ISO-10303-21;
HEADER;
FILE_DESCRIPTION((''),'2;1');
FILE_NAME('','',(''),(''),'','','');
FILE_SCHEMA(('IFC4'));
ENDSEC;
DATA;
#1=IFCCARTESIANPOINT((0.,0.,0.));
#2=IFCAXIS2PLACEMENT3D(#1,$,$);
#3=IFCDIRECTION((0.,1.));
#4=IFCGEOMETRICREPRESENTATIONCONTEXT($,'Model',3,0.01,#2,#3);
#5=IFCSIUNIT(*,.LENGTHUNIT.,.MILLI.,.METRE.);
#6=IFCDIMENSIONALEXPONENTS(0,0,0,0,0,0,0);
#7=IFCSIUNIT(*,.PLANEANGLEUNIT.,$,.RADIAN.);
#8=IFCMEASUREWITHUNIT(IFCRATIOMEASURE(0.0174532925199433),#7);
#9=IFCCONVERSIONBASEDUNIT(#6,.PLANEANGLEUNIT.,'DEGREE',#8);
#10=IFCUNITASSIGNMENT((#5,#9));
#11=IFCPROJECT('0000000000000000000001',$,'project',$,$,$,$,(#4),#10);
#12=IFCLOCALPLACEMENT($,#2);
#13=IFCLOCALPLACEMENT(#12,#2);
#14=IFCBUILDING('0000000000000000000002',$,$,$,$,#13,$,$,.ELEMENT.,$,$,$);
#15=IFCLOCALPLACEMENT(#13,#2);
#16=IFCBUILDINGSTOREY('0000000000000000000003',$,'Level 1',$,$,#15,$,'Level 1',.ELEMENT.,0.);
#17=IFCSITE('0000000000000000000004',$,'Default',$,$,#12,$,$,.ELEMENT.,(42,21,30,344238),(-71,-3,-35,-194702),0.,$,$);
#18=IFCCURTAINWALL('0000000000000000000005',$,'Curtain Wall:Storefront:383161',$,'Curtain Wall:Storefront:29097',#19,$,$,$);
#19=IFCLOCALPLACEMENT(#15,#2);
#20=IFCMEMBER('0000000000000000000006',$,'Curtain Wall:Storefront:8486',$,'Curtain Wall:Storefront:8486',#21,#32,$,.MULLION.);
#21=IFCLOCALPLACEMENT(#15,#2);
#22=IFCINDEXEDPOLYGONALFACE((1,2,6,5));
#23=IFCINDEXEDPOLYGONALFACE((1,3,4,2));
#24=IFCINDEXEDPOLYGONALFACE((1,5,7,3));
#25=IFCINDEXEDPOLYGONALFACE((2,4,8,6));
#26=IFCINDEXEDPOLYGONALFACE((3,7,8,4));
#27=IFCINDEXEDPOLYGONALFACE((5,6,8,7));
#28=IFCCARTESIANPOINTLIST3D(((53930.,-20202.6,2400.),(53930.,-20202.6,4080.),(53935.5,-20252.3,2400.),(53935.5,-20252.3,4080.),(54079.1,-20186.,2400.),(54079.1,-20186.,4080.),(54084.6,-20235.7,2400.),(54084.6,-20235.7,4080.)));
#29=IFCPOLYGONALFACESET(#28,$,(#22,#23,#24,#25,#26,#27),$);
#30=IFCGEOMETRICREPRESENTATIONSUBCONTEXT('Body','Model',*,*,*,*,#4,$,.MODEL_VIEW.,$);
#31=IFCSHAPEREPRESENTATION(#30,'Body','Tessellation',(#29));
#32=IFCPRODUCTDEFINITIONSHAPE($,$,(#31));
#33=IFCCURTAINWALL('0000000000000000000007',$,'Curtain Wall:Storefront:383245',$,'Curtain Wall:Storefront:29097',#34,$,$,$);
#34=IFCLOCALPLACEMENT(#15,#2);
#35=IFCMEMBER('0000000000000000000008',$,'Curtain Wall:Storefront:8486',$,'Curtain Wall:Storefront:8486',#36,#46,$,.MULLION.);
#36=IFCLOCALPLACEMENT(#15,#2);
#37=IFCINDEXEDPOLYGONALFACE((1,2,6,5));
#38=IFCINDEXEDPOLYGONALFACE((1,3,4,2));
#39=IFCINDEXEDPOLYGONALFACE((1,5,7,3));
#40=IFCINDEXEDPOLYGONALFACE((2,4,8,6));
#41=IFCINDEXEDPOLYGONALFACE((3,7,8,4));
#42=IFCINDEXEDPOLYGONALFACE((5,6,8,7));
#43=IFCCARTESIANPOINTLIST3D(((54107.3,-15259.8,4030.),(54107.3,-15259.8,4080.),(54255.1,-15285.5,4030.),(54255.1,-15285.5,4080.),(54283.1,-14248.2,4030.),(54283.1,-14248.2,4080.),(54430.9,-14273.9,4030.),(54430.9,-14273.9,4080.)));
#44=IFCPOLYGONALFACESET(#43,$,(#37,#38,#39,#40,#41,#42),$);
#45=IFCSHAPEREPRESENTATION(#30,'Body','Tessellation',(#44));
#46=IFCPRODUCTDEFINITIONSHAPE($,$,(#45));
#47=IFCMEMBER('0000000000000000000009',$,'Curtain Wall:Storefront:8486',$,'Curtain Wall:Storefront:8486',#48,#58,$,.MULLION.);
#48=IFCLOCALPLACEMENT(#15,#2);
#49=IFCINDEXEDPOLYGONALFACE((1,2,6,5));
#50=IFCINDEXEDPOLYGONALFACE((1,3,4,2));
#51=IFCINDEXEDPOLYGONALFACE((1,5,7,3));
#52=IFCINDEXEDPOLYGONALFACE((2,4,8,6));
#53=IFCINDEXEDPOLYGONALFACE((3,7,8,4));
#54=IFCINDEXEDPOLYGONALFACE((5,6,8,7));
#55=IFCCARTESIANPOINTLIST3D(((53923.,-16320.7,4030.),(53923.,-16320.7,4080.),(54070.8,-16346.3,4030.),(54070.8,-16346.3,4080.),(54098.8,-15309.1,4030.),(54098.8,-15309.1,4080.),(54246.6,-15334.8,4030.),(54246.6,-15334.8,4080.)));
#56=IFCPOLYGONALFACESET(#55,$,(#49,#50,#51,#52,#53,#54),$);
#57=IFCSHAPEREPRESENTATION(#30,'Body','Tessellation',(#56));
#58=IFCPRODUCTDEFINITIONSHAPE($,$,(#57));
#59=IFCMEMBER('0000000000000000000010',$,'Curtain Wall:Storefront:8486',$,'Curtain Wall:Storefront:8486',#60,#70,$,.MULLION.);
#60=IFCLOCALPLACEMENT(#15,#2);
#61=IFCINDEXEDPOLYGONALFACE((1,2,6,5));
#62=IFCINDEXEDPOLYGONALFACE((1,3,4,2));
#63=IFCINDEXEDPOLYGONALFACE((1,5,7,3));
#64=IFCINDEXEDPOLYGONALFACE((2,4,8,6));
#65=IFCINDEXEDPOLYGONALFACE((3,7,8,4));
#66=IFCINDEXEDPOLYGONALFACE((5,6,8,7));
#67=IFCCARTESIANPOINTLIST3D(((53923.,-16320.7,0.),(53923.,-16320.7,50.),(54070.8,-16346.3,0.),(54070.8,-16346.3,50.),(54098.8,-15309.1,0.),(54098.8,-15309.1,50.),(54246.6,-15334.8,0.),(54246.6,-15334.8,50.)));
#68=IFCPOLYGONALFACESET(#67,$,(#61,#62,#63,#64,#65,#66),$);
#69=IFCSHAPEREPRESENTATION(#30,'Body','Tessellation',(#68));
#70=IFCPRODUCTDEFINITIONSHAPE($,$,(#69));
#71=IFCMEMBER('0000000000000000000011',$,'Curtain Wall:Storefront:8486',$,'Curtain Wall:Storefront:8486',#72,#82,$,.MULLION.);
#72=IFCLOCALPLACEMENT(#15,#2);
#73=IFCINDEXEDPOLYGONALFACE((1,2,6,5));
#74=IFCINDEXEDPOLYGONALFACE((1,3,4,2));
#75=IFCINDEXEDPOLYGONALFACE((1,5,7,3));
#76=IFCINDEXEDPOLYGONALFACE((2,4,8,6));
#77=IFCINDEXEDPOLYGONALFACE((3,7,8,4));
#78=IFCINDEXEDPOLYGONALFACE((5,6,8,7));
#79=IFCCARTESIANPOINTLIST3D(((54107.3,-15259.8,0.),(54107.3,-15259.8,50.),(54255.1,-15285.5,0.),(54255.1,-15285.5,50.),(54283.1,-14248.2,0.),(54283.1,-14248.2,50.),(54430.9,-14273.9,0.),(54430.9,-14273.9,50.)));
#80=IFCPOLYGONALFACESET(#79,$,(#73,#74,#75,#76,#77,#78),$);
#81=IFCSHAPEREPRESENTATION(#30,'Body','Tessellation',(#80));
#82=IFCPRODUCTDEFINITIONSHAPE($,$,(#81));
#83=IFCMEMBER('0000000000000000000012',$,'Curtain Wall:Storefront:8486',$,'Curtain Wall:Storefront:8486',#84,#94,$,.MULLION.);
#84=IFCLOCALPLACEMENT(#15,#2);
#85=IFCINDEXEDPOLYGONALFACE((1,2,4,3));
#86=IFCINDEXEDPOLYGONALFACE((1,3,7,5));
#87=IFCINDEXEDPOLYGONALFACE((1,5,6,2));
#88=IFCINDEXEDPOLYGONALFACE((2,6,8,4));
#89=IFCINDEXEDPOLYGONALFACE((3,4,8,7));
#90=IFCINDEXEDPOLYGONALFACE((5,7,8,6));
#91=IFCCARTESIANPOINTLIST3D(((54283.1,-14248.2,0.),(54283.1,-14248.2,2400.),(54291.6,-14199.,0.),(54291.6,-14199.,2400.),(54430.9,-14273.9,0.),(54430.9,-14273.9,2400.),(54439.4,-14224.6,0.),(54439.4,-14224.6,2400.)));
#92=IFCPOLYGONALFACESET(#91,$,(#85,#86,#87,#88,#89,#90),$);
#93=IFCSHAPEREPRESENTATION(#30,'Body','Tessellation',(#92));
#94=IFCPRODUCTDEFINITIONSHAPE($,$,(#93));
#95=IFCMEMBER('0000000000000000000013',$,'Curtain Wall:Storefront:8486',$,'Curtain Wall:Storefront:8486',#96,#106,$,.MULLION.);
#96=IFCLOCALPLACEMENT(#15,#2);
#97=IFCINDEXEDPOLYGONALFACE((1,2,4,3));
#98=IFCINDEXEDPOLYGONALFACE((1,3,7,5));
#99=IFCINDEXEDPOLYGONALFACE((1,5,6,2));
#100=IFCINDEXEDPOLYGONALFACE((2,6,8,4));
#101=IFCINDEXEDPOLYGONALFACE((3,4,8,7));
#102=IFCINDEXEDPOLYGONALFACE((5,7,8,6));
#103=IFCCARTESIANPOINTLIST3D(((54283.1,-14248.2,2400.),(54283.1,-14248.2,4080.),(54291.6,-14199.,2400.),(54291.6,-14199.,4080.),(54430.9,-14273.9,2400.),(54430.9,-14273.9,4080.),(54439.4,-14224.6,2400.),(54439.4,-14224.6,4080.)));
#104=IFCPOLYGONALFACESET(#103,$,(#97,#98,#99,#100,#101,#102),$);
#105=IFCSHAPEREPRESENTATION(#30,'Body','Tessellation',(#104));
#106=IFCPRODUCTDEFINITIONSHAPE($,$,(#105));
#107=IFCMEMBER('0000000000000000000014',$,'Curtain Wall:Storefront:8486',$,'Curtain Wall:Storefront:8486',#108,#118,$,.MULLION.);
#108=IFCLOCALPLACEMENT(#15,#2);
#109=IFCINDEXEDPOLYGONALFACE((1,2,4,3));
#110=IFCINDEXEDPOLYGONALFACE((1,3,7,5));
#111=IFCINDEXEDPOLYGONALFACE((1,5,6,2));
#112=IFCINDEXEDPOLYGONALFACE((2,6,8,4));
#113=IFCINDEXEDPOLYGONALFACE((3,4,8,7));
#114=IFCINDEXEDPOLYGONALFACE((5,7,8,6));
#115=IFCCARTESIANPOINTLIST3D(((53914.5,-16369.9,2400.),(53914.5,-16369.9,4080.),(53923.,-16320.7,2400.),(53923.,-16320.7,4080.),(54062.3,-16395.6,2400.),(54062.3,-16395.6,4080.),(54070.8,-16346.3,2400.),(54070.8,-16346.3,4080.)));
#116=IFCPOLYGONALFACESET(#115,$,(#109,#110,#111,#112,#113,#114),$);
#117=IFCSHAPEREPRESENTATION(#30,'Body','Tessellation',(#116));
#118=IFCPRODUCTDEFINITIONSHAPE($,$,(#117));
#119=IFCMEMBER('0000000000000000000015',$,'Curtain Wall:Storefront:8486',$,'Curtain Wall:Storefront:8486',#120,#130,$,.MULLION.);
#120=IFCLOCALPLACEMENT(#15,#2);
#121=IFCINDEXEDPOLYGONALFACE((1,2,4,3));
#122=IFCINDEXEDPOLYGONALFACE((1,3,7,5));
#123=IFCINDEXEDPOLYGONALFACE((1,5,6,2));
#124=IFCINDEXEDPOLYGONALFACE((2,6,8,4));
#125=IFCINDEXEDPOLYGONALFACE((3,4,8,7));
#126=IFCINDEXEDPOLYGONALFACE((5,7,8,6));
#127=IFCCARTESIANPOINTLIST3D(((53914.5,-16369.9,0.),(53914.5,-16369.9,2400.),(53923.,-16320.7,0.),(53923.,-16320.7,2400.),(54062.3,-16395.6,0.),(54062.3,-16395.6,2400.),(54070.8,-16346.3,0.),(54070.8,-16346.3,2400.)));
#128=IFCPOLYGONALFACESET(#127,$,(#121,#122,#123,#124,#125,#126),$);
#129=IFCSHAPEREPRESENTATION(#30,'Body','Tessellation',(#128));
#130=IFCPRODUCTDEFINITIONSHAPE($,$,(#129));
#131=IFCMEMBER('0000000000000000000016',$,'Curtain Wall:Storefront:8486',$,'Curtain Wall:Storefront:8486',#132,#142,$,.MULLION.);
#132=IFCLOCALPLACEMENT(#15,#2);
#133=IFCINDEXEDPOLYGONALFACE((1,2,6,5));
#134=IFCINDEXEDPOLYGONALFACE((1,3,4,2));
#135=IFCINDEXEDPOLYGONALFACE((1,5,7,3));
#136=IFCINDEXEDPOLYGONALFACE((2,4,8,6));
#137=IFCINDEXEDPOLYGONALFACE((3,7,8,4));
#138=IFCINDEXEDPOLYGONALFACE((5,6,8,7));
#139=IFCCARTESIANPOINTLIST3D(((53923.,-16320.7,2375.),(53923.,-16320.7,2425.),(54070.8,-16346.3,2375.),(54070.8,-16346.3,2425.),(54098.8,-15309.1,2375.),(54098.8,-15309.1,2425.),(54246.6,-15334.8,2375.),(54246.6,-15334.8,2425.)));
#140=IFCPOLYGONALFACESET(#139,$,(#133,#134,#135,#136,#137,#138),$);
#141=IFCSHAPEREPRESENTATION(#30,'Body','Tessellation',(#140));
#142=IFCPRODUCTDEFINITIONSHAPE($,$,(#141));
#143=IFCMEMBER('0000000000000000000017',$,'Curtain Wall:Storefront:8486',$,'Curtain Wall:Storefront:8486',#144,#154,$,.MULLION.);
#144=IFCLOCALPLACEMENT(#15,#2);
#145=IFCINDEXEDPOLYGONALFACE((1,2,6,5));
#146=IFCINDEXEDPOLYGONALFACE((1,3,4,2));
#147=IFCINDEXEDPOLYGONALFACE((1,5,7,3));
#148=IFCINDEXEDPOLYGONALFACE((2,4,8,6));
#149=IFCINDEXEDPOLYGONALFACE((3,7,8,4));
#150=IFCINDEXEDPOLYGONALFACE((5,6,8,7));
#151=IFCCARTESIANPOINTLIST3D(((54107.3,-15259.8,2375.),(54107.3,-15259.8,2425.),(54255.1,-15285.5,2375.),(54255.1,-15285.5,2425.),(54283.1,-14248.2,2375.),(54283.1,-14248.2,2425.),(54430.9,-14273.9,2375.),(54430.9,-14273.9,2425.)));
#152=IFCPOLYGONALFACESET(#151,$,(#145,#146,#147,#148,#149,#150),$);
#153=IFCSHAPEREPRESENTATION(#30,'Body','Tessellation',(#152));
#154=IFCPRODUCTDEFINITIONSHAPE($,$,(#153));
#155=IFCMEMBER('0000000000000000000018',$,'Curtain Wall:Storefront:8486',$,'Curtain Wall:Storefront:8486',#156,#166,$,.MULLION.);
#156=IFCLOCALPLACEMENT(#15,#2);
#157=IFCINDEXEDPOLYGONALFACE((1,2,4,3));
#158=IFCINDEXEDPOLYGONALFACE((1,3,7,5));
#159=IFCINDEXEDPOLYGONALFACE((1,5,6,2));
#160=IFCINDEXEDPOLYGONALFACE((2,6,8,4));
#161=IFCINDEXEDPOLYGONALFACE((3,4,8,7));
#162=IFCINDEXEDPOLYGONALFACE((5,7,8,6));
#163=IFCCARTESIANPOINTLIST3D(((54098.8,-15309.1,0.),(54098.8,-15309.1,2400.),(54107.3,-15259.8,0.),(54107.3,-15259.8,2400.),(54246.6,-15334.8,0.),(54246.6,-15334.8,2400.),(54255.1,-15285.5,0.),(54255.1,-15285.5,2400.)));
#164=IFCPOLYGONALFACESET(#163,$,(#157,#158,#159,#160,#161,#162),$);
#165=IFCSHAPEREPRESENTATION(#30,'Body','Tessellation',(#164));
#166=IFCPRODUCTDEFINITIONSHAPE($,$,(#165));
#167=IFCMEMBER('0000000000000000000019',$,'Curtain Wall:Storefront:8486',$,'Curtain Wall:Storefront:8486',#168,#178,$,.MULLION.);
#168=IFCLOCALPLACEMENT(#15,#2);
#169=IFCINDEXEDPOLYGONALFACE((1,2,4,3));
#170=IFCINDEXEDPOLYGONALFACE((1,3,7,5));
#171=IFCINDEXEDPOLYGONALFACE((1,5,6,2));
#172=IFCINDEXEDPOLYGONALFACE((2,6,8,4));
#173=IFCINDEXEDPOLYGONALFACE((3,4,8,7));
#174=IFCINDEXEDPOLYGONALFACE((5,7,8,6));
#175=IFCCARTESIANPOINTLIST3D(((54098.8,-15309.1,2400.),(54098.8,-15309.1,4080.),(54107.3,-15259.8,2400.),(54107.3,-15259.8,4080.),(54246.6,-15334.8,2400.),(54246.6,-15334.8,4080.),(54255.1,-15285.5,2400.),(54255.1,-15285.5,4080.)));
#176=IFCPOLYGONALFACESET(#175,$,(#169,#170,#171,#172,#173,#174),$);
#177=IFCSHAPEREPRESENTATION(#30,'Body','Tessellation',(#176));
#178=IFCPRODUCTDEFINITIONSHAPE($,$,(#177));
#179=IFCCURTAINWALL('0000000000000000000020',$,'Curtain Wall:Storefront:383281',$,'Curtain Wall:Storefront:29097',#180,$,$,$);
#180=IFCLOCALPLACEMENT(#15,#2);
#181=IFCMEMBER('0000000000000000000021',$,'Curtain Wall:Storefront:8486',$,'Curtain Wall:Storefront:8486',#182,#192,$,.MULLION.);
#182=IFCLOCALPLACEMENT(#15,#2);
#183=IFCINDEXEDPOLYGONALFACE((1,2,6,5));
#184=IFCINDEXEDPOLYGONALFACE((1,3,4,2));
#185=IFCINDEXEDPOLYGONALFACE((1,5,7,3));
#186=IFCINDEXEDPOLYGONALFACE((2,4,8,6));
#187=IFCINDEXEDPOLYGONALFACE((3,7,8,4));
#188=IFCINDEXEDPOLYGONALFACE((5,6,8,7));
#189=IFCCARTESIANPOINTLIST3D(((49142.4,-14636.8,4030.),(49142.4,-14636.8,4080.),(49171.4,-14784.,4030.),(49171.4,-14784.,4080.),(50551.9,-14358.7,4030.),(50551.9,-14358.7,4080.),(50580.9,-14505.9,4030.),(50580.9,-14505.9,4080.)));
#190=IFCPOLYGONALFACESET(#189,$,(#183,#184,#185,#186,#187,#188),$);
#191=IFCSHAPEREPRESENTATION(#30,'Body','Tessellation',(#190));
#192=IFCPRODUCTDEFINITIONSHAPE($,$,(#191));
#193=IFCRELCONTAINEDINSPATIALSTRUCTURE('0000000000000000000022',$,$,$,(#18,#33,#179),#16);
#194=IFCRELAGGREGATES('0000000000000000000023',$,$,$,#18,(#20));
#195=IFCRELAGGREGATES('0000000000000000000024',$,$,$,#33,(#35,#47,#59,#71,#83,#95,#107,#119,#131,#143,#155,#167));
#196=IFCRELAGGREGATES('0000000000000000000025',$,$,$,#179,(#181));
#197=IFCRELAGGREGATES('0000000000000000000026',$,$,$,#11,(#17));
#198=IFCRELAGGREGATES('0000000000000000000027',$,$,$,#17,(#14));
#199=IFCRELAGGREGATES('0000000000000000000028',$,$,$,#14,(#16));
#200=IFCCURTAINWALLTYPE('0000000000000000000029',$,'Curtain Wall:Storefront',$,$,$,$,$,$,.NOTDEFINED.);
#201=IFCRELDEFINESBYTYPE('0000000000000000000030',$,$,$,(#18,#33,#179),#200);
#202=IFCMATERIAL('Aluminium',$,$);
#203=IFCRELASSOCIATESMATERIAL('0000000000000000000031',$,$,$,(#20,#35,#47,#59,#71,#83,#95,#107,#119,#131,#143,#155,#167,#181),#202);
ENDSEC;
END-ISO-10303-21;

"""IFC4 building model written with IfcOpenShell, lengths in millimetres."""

from ifc_helpers import new_model, entity, si_unit, converted_unit, direction, frame, frame_2d, origin, origin_2d_with_axis, place, context, subcontext, project, spatial, rectangle, extrude, material, type_object, element, aggregate, save


model = new_model("IFC4")

# Units and contexts
model_context = context("Model", 3, precision=0.01, world=origin(), true_north=direction((0.0, 1.0)))
body_context = subcontext(model_context, "Body", "Model", "MODEL_VIEW")
ifc_project = project(units=[si_unit("LENGTHUNIT", "METRE", prefix="MILLI"), converted_unit("PLANEANGLEUNIT", "DEGREE", entity("IfcRatioMeasure", 0.0174532925199433), si_unit("PLANEANGLEUNIT", "RADIAN"), dimensions=[0, 0, 0, 0, 0, 0, 0])], contexts=[model_context])

# Site, building, storey
site_placement = place(None, origin())
site = spatial("IfcSite", under=ifc_project, at=site_placement, Name="Default", CompositionType="ELEMENT", RefLatitude=(42, 21, 30, 344238), RefLongitude=(-71, -3, -35, -194702), RefElevation=0.0)
building_placement = place(site_placement, origin())
building = spatial("IfcBuilding", under=site, at=building_placement, CompositionType="ELEMENT")
storey_placement = place(building_placement, origin())
storey = spatial("IfcBuildingStorey", under=building, at=storey_placement, Name="Level 1", LongName="Level 1", CompositionType="ELEMENT", Elevation=0.0)

# Curtain walls, members
curtain_wall_type = type_object("IfcCurtainWallType", Name="Curtain Wall:Storefront", PredefinedType="NOTDEFINED")
ifc_material = material(Name="Aluminium")
curtain_wall_1_placement = place(storey_placement, origin())
curtain_wall_1 = element("IfcCurtainWall", 1, at=curtain_wall_1_placement, inside=storey, type_object=curtain_wall_type, Name="Curtain Wall:Storefront:383161", ObjectType="Curtain Wall:Storefront:29097")
member_1_placement = place(curtain_wall_1_placement, origin())
member_1 = element("IfcMember", 2, at=member_1_placement, material=ifc_material, Name="Curtain Wall:Storefront:8486", ObjectType="Curtain Wall:Storefront:8486", PredefinedType="MULLION", context=body_context, shape_type="SweptSolid", body=[
    extrude(rectangle(XDim=50.0, YDim=150.0, at=origin_2d_with_axis()), frame((54007.3, -20219.1, 2400.0), z_axis=(0.0, 0.0, 1.0), x_axis=(-0.110402, 0.993887, 0.0)), (0.0, 0.0, 1.0), 1680.0),
])
aggregate(curtain_wall_1, [member_1])
curtain_wall_2_placement = place(storey_placement, origin())
curtain_wall_2 = element("IfcCurtainWall", 3, at=curtain_wall_2_placement, inside=storey, type_object=curtain_wall_type, Name="Curtain Wall:Storefront:383245", ObjectType="Curtain Wall:Storefront:29097")
member_2_placement = place(curtain_wall_2_placement, origin())
member_2 = element("IfcMember", 4, at=member_2_placement, material=ifc_material, Name="Curtain Wall:Storefront:8486", ObjectType="Curtain Wall:Storefront:8486", PredefinedType="MULLION", context=body_context, shape_type="SweptSolid", body=[
    extrude(rectangle(XDim=50.0, YDim=150.0, at=frame_2d((0.0, 0.0), x_axis=(1.0, 0.0))), frame((54357.0, -14261.1, 4055.0), z_axis=(-0.171153, -0.985244, 0.0), x_axis=(0.0, 0.0, -1.0)), (0.0, 0.0, 1.0), 1026.7),
])
member_3_placement = place(curtain_wall_2_placement, origin())
member_3 = element("IfcMember", 5, at=member_3_placement, material=ifc_material, Name="Curtain Wall:Storefront:8486", ObjectType="Curtain Wall:Storefront:8486", PredefinedType="MULLION", context=body_context, shape_type="SweptSolid", body=[
    extrude(rectangle(XDim=50.0, YDim=150.0, at=frame_2d((0.0, 0.0), x_axis=(1.0, 0.0))), frame((54172.7, -15321.9, 4055.0), z_axis=(-0.171153, -0.985244, 0.0), x_axis=(0.0, 0.0, -1.0)), (0.0, 0.0, 1.0), 1026.7),
])
member_4_placement = place(curtain_wall_2_placement, origin())
member_4 = element("IfcMember", 6, at=member_4_placement, material=ifc_material, Name="Curtain Wall:Storefront:8486", ObjectType="Curtain Wall:Storefront:8486", PredefinedType="MULLION", context=body_context, shape_type="SweptSolid", body=[
    extrude(rectangle(XDim=50.0, YDim=150.0, at=origin_2d_with_axis()), frame((53996.9, -16333.5, 25.0), z_axis=(0.171153, 0.985244, 0.0), x_axis=(0.0, 0.0, -1.0)), (0.0, 0.0, 1.0), 1026.7),
])
member_5_placement = place(curtain_wall_2_placement, origin())
member_5 = element("IfcMember", 7, at=member_5_placement, material=ifc_material, Name="Curtain Wall:Storefront:8486", ObjectType="Curtain Wall:Storefront:8486", PredefinedType="MULLION", context=body_context, shape_type="SweptSolid", body=[
    extrude(rectangle(XDim=50.0, YDim=150.0, at=origin_2d_with_axis()), frame((54181.2, -15272.7, 25.0), z_axis=(0.171153, 0.985244, 0.0), x_axis=(0.0, 0.0, -1.0)), (0.0, 0.0, 1.0), 1026.7),
])
member_6_placement = place(curtain_wall_2_placement, origin())
member_6 = element("IfcMember", 8, at=member_6_placement, material=ifc_material, Name="Curtain Wall:Storefront:8486", ObjectType="Curtain Wall:Storefront:8486", PredefinedType="MULLION", context=body_context, shape_type="SweptSolid", body=[
    extrude(rectangle(XDim=50.0, YDim=150.0, at=frame_2d((0.0, 0.0), x_axis=(1.0, 0.0))), frame((54361.2, -14236.4, 0.0), z_axis=(0.0, 0.0, 1.0), x_axis=(0.171153, 0.985244, 0.0)), (0.0, 0.0, 1.0), 2400.0),
])
member_7_placement = place(curtain_wall_2_placement, origin())
member_7 = element("IfcMember", 9, at=member_7_placement, material=ifc_material, Name="Curtain Wall:Storefront:8486", ObjectType="Curtain Wall:Storefront:8486", PredefinedType="MULLION", context=body_context, shape_type="SweptSolid", body=[
    extrude(rectangle(XDim=50.0, YDim=150.0, at=frame_2d((0.0, 0.0), x_axis=(1.0, 0.0))), frame((54361.2, -14236.4, 2400.0), z_axis=(0.0, 0.0, 1.0), x_axis=(0.171153, 0.985244, 0.0)), (0.0, 0.0, 1.0), 1680.0),
])
member_8_placement = place(curtain_wall_2_placement, origin())
member_8 = element("IfcMember", 10, at=member_8_placement, material=ifc_material, Name="Curtain Wall:Storefront:8486", ObjectType="Curtain Wall:Storefront:8486", PredefinedType="MULLION", context=body_context, shape_type="SweptSolid", body=[
    extrude(rectangle(XDim=50.0, YDim=150.0, at=frame_2d((0.0, 0.0), x_axis=(1.0, 0.0))), frame((53992.7, -16358.1, 4080.0), z_axis=(0.0, 0.0, -1.0), x_axis=(-0.171153, -0.985244, 0.0)), (0.0, 0.0, 1.0), 1680.0),
])
member_9_placement = place(curtain_wall_2_placement, origin())
member_9 = element("IfcMember", 11, at=member_9_placement, material=ifc_material, Name="Curtain Wall:Storefront:8486", ObjectType="Curtain Wall:Storefront:8486", PredefinedType="MULLION", context=body_context, shape_type="SweptSolid", body=[
    extrude(rectangle(XDim=50.0, YDim=150.0, at=frame_2d((0.0, 0.0), x_axis=(1.0, 0.0))), frame((53992.7, -16358.1, 2400.0), z_axis=(0.0, 0.0, -1.0), x_axis=(-0.171153, -0.985244, 0.0)), (0.0, 0.0, 1.0), 2400.0),
])
member_10_placement = place(curtain_wall_2_placement, origin())
member_10 = element("IfcMember", 12, at=member_10_placement, material=ifc_material, Name="Curtain Wall:Storefront:8486", ObjectType="Curtain Wall:Storefront:8486", PredefinedType="MULLION", context=body_context, shape_type="SweptSolid", body=[
    extrude(rectangle(XDim=50.0, YDim=150.0, at=frame_2d((0.0, 0.0), x_axis=(1.0, 0.0))), frame((54172.7, -15321.9, 2400.0), z_axis=(-0.171153, -0.985244, 0.0), x_axis=(0.0, 0.0, -1.0)), (0.0, 0.0, 1.0), 1026.7),
])
member_11_placement = place(curtain_wall_2_placement, origin())
member_11 = element("IfcMember", 13, at=member_11_placement, material=ifc_material, Name="Curtain Wall:Storefront:8486", ObjectType="Curtain Wall:Storefront:8486", PredefinedType="MULLION", context=body_context, shape_type="SweptSolid", body=[
    extrude(rectangle(XDim=50.0, YDim=150.0, at=origin_2d_with_axis()), frame((54357.0, -14261.1, 2400.0), z_axis=(-0.171153, -0.985244, 0.0), x_axis=(0.0, 0.0, -1.0)), (0.0, 0.0, 1.0), 1026.7),
])
member_12_placement = place(curtain_wall_2_placement, origin())
member_12 = element("IfcMember", 14, at=member_12_placement, material=ifc_material, Name="Curtain Wall:Storefront:8486", ObjectType="Curtain Wall:Storefront:8486", PredefinedType="MULLION", context=body_context, shape_type="SweptSolid", body=[
    extrude(rectangle(XDim=50.0, YDim=150.0, at=origin_2d_with_axis()), frame((54176.9, -15297.3, 0.0), z_axis=(0.0, 0.0, 1.0), x_axis=(0.171153, 0.985244, 0.0)), (0.0, 0.0, 1.0), 2400.0),
])
member_13_placement = place(curtain_wall_2_placement, origin())
member_13 = element("IfcMember", 15, at=member_13_placement, material=ifc_material, Name="Curtain Wall:Storefront:8486", ObjectType="Curtain Wall:Storefront:8486", PredefinedType="MULLION", context=body_context, shape_type="SweptSolid", body=[
    extrude(rectangle(XDim=50.0, YDim=150.0, at=origin_2d_with_axis()), frame((54176.9, -15297.3, 2400.0), z_axis=(0.0, 0.0, 1.0), x_axis=(0.171153, 0.985244, 0.0)), (0.0, 0.0, 1.0), 1680.0),
])
aggregate(curtain_wall_2, [member_2, member_3, member_4, member_5, member_6, member_7, member_8, member_9, member_10, member_11, member_12, member_13])
curtain_wall_3_placement = place(storey_placement, origin())
curtain_wall_3 = element("IfcCurtainWall", 16, at=curtain_wall_3_placement, inside=storey, type_object=curtain_wall_type, Name="Curtain Wall:Storefront:383281", ObjectType="Curtain Wall:Storefront:29097")
member_14_placement = place(curtain_wall_3_placement, origin())
member_14 = element("IfcMember", 17, at=member_14_placement, material=ifc_material, Name="Curtain Wall:Storefront:8486", ObjectType="Curtain Wall:Storefront:8486", PredefinedType="MULLION", context=body_context, shape_type="SweptSolid", body=[
    extrude(rectangle(XDim=50.0, YDim=150.0, at=frame_2d((0.0, 0.0), x_axis=(1.0, 0.0))), frame((49156.9, -14710.4, 4055.0), z_axis=(0.981087, 0.193568, 0.0), x_axis=(0.0, 0.0, -1.0)), (0.0, 0.0, 1.0), 1436.7),
])
aggregate(curtain_wall_3, [member_14])

save(model, "model.ifc")
